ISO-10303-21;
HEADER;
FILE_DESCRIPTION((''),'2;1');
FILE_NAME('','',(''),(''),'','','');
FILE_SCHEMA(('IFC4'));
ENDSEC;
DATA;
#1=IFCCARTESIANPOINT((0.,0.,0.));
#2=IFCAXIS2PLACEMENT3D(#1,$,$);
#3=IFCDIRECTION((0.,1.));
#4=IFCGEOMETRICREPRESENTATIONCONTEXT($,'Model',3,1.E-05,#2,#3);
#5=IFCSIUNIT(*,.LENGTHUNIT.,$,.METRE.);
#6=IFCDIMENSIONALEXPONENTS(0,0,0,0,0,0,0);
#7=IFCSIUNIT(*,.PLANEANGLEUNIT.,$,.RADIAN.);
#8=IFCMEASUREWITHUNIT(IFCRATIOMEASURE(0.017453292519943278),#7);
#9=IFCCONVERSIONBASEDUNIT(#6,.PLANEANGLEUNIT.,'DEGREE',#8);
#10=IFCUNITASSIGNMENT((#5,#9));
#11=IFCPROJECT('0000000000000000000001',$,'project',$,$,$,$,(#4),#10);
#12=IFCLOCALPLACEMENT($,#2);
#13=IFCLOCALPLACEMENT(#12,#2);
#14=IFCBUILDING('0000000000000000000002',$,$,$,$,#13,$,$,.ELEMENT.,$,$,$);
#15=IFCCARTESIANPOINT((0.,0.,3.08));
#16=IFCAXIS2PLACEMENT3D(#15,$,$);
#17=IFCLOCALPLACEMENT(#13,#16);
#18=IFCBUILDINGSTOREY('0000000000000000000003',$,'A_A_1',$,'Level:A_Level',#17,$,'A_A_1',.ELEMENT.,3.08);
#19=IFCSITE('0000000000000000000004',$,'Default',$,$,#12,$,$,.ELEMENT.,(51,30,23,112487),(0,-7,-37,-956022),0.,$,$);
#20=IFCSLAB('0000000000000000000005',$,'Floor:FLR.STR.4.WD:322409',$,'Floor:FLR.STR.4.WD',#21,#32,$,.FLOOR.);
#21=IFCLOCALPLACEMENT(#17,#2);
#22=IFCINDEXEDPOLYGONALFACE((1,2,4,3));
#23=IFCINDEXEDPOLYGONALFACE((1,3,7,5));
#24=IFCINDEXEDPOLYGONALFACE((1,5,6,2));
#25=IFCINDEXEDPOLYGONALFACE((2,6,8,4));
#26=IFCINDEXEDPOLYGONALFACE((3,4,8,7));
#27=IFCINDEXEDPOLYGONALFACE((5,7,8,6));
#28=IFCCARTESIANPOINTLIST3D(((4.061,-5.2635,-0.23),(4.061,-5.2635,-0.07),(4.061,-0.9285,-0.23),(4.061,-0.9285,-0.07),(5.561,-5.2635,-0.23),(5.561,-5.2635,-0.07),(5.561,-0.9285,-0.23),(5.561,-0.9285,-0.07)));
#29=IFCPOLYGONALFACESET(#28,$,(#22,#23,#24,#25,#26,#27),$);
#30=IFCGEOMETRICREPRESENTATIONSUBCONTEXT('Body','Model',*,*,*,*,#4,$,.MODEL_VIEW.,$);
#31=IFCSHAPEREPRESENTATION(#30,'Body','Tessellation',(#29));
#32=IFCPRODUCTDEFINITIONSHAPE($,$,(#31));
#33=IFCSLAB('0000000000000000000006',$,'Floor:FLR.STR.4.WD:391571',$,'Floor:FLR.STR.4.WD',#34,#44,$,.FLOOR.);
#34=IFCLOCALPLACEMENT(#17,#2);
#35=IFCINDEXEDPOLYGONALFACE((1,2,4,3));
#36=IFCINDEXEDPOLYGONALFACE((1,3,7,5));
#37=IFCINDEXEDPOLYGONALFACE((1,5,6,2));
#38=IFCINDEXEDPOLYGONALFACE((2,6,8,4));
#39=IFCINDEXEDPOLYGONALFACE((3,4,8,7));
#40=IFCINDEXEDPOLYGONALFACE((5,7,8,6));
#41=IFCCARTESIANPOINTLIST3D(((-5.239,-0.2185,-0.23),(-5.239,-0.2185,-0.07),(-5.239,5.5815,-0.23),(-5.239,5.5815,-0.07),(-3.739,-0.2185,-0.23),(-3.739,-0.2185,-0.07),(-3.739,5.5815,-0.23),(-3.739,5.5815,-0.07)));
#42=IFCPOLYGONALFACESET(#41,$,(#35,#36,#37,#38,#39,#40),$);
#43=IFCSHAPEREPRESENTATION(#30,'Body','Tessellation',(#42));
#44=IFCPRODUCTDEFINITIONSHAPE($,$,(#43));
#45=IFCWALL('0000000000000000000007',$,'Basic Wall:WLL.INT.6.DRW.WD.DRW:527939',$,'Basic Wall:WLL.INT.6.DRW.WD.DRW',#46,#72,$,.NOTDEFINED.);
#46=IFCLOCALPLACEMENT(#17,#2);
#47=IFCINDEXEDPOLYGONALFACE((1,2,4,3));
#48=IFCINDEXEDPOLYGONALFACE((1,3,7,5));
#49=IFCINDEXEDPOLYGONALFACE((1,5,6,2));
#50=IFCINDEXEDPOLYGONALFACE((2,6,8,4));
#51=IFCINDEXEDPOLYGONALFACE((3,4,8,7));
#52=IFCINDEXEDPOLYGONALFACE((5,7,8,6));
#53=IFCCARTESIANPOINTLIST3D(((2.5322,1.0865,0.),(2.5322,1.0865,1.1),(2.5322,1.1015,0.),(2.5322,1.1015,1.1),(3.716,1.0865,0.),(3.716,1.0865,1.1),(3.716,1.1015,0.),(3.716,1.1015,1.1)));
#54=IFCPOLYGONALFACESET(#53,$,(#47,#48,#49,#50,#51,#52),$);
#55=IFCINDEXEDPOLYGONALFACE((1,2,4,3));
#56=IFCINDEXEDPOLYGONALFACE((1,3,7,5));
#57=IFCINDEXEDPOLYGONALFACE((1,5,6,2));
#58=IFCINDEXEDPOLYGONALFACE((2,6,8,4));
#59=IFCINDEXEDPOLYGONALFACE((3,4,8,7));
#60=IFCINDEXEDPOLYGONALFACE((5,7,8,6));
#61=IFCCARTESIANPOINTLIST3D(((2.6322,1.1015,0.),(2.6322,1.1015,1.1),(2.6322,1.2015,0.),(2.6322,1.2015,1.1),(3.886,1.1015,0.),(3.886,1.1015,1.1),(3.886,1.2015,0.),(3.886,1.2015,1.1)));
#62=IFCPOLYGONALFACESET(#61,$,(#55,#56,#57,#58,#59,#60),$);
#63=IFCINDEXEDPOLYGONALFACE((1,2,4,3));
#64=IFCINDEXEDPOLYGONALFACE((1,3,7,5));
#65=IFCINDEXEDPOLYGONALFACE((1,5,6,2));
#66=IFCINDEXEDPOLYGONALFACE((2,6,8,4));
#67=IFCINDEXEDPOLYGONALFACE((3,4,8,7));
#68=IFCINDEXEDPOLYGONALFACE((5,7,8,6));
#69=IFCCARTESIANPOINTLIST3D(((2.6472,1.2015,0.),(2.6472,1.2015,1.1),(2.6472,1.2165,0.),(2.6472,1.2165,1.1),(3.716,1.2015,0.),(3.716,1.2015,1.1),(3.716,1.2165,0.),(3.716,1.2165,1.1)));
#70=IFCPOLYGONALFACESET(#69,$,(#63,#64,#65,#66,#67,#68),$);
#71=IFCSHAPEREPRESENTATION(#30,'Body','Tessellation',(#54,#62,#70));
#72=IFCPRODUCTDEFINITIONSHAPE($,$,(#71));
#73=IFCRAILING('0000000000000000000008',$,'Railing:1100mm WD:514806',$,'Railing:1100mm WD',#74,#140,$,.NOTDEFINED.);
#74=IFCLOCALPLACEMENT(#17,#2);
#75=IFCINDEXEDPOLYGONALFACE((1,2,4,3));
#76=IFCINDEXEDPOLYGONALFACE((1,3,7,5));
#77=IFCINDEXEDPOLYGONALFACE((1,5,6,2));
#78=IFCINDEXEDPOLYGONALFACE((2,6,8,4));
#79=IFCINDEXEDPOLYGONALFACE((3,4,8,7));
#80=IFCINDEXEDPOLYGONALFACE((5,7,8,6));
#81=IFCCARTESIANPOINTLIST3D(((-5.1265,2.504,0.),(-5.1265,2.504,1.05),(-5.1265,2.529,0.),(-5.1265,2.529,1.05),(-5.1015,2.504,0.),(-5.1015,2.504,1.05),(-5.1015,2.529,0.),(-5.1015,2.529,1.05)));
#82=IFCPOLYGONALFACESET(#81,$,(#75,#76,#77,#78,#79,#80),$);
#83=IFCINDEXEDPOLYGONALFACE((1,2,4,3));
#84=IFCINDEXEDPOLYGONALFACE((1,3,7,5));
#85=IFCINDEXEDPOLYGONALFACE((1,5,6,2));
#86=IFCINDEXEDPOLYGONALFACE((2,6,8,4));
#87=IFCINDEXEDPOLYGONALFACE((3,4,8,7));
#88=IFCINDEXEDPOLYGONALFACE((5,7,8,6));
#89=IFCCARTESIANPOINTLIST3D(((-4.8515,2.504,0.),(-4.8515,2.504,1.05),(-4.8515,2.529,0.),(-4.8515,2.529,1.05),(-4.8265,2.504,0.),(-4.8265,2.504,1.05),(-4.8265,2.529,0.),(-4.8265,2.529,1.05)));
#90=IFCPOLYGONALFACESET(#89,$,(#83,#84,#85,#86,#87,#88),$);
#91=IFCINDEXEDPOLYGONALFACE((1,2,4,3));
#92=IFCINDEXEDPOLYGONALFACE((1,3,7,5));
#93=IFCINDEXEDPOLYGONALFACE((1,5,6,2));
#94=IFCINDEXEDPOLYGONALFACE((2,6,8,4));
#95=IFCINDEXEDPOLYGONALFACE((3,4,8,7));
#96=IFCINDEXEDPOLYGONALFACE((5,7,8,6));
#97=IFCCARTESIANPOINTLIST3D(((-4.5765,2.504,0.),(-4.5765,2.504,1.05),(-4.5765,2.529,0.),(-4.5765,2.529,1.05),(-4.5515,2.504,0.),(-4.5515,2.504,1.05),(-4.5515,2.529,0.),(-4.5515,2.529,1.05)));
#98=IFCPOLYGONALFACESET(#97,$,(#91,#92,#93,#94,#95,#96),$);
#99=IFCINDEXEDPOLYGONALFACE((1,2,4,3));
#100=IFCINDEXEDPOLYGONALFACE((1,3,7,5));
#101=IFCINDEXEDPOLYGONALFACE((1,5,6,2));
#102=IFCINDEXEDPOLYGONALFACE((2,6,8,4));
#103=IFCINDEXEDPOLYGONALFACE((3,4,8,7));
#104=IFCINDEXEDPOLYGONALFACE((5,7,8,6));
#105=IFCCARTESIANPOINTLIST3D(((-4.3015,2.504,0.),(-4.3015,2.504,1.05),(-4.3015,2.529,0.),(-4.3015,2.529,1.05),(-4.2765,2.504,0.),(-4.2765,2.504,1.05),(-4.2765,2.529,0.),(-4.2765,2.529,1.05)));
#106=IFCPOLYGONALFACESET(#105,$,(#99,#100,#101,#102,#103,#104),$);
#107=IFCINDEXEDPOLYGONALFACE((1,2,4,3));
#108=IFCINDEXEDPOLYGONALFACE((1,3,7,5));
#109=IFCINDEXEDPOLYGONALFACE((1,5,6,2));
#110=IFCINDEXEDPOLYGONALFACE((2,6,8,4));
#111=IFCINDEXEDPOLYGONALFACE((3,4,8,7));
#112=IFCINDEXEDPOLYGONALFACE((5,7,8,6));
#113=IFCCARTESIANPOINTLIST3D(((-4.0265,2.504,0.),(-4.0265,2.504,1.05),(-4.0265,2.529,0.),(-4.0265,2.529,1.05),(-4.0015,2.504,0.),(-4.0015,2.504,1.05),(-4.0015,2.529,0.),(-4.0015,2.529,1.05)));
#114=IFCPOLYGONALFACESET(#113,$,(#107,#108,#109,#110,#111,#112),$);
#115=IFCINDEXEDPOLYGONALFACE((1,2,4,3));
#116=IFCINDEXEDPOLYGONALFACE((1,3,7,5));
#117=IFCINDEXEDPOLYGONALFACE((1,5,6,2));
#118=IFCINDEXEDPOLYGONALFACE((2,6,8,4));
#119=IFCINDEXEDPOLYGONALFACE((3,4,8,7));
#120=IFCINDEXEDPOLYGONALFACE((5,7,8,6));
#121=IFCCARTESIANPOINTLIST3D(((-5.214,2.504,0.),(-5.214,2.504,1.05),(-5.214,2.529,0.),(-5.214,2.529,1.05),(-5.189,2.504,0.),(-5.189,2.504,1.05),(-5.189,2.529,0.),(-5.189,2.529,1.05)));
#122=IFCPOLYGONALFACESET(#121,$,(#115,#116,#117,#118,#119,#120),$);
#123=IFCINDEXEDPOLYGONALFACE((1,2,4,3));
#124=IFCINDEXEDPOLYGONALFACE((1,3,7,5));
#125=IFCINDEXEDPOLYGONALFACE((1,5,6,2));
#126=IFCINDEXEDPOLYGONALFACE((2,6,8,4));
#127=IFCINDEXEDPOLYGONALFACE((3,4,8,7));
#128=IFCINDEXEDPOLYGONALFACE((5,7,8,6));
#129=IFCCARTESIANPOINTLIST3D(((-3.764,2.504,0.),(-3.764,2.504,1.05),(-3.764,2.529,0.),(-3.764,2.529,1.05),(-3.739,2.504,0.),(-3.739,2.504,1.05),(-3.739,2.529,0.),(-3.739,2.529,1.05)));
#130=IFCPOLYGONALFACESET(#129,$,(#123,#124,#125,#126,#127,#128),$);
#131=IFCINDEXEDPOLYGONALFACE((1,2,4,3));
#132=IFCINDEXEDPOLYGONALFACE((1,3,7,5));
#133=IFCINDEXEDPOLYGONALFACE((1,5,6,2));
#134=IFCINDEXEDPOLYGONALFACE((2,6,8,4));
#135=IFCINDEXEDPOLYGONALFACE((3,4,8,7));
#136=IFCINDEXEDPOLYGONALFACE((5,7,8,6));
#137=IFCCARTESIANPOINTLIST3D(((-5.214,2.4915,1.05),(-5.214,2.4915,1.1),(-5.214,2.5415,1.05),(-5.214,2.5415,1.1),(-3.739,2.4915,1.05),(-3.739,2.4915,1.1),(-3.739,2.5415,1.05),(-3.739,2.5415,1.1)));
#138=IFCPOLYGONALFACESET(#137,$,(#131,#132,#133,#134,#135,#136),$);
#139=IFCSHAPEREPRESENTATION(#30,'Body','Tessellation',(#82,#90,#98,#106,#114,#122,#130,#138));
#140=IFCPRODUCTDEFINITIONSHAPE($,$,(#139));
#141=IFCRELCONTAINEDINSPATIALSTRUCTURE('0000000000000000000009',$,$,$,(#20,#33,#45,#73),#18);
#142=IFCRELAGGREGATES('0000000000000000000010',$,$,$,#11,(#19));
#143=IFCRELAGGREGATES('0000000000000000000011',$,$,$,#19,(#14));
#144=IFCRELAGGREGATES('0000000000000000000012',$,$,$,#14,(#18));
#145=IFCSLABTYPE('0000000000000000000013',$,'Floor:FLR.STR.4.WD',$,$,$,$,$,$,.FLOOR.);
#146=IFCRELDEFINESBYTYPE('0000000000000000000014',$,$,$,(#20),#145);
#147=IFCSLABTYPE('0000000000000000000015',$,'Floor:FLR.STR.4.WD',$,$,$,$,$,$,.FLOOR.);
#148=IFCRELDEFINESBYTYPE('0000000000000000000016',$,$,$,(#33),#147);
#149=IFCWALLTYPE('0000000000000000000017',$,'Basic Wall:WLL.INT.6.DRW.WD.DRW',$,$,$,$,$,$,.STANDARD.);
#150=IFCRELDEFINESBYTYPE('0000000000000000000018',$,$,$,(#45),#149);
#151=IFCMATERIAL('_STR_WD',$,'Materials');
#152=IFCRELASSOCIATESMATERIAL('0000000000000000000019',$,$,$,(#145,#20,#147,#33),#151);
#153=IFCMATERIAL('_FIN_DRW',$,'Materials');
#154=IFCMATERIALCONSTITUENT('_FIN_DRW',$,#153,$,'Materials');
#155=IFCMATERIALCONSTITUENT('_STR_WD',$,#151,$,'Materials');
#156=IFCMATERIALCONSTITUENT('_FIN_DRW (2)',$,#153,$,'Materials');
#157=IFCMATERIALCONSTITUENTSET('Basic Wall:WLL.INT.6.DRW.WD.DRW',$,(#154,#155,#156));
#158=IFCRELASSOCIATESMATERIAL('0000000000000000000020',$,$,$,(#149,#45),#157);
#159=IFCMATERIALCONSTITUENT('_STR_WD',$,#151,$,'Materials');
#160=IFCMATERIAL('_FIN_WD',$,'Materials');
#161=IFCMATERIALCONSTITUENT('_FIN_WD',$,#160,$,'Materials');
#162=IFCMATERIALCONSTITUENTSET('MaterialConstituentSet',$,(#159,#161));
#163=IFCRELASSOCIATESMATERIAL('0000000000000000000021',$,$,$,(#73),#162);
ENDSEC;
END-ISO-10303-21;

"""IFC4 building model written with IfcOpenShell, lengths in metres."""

from ifc_helpers import new_model, entity, si_unit, converted_unit, direction, frame, origin, place, context, subcontext, project, spatial, indexed_curve, outline, extrude, material, constituent, constituent_set, type_object, element, save


model = new_model("IFC4")

# Units and contexts
model_context = context("Model", 3, precision=1e-05, world=origin(), true_north=direction((0.0, 1.0)))
body_context = subcontext(model_context, "Body", "Model", "MODEL_VIEW")
ifc_project = project(units=[si_unit("LENGTHUNIT", "METRE"), converted_unit("PLANEANGLEUNIT", "DEGREE", entity("IfcRatioMeasure", 0.017453292519943278), si_unit("PLANEANGLEUNIT", "RADIAN"), dimensions=[0, 0, 0, 0, 0, 0, 0])], contexts=[model_context])

# Site, building, storey
site_placement = place(None, origin())
site = spatial("IfcSite", under=ifc_project, at=site_placement, Name="Default", CompositionType="ELEMENT", RefLatitude=(51, 30, 23, 112487), RefLongitude=(0, -7, -37, -956022), RefElevation=0.0)
building_placement = place(site_placement, origin())
building = spatial("IfcBuilding", under=site, at=building_placement, CompositionType="ELEMENT")
storey_placement = place(building_placement, frame((0.0, 0.0, 3.08)))
storey = spatial("IfcBuildingStorey", under=building, at=storey_placement, Name="A_A_1", ObjectType="Level:A_Level", LongName="A_A_1", CompositionType="ELEMENT", Elevation=3.08)

# Slabs
ifc_material_1 = material(Name="_FIN_WD", Category="Materials")
ifc_material_2 = material(Name="_STR_WD", Category="Materials")
slab_type_1 = type_object("IfcSlabType", Name="Floor:FLR.STR.4.WD", PredefinedType="FLOOR", material=ifc_material_2)
slab_1_placement = place(storey_placement, origin())
element("IfcSlab", 1, at=slab_1_placement, inside=storey, type_object=slab_type_1, material=ifc_material_2, Name="Floor:FLR.STR.4.WD:322409", ObjectType="Floor:FLR.STR.4.WD", PredefinedType="FLOOR", context=body_context, shape_type="SweptSolid", body=[
    extrude(outline(indexed_curve([(-0.75, -2.1675), (0.75, -2.1675), (0.75, 2.1675), (-0.75, 2.1675), (-0.75, -2.1675)], self_intersect=False)), frame((4.811, -3.096, -0.07), z_axis=(0.0, 0.0, -1.0), x_axis=(1.0, 0.0, 0.0)), (0.0, 0.0, 1.0), 0.16),
])
slab_type_2 = type_object("IfcSlabType", Name="Floor:FLR.STR.4.WD", PredefinedType="FLOOR", material=ifc_material_2)
slab_2_placement = place(storey_placement, origin())
element("IfcSlab", 2, at=slab_2_placement, inside=storey, type_object=slab_type_2, material=ifc_material_2, Name="Floor:FLR.STR.4.WD:391571", ObjectType="Floor:FLR.STR.4.WD", PredefinedType="FLOOR", context=body_context, shape_type="SweptSolid", body=[
    extrude(outline(indexed_curve([(-2.9, -0.75), (2.9, -0.75), (2.9, 0.75), (-2.9, 0.75), (-2.9, -0.75)], self_intersect=False)), frame((-4.489, 2.6815, -0.07), z_axis=(0.0, 0.0, -1.0), x_axis=(0.0, 1.0, 0.0)), (0.0, 0.0, 1.0), 0.16),
])

# Shared definitions
ifc_material_3 = material(Name="_FIN_DRW", Category="Materials")
ifc_constituent_1 = constituent(ifc_material_3, Name="_FIN_DRW", Category="Materials")
ifc_constituent_2 = constituent(ifc_material_2, Name="_STR_WD", Category="Materials")
ifc_constituent_3 = constituent(ifc_material_3, Name="_FIN_DRW (2)", Category="Materials")
ifc_constituent_set_1 = constituent_set(constituents=[ifc_constituent_1, ifc_constituent_2, ifc_constituent_3], Name="Basic Wall:WLL.INT.6.DRW.WD.DRW")
wall_type = type_object("IfcWallType", Name="Basic Wall:WLL.INT.6.DRW.WD.DRW", PredefinedType="STANDARD", material=ifc_constituent_set_1)

# Wall
wall_1_placement = place(storey_placement, frame((2.6472, 1.1515, 0.0)))
element("IfcWall", 3, at=wall_1_placement, inside=storey, type_object=wall_type, material=ifc_constituent_set_1, Name="Basic Wall:WLL.INT.6.DRW.WD.DRW:527939", ObjectType="Basic Wall:WLL.INT.6.DRW.WD.DRW", PredefinedType="NOTDEFINED", context=body_context, shape_type="SweptSolid", body=[
    extrude(outline(indexed_curve([(-0.0075, -0.5919), (0.0075, -0.5919), (0.0075, 0.5919), (-0.0075, 0.5919), (-0.0075, -0.5919)], self_intersect=False)), frame((0.4769, -0.0575, 0.0), z_axis=(0.0, 0.0, 1.0), x_axis=(0.0, 1.0, 0.0)), (0.0, 0.0, 1.0), 1.1),
    extrude(outline(indexed_curve([(-0.6269, -0.05), (0.6269, -0.05), (0.6269, 0.05), (-0.6269, 0.05), (-0.6269, -0.05)], self_intersect=False)), frame((0.6119, 0.0, 0.0)), (0.0, 0.0, 1.0), 1.1),
    extrude(outline(indexed_curve([(-0.0075, -0.5344), (0.0075, -0.5344), (0.0075, 0.5344), (-0.0075, 0.5344), (-0.0075, -0.5344)], self_intersect=False)), frame((0.5344, 0.0575, 0.0), z_axis=(0.0, 0.0, 1.0), x_axis=(0.0, -1.0, 0.0)), (0.0, 0.0, 1.0), 1.1),
])

# Railing
ifc_constituent_4 = constituent(ifc_material_2, Name="_STR_WD", Category="Materials")
ifc_constituent_5 = constituent(ifc_material_1, Name="_FIN_WD", Category="Materials")
ifc_constituent_set_2 = constituent_set(constituents=[ifc_constituent_4, ifc_constituent_5], Name="MaterialConstituentSet")
railing_placement = place(storey_placement, origin())
element("IfcRailing", 4, at=railing_placement, inside=storey, material=ifc_constituent_set_2, Name="Railing:1100mm WD:514806", ObjectType="Railing:1100mm WD", PredefinedType="NOTDEFINED", context=body_context, shape_type="SweptSolid", body=[
    extrude(outline(indexed_curve([(-0.0125, -0.0125), (0.0125, -0.0125), (0.0125, 0.0125), (-0.0125, 0.0125), (-0.0125, -0.0125)], self_intersect=False)), frame((-5.114, 2.5165, 0.0), z_axis=(0.0, 0.0, 1.0), x_axis=(-1.0, 0.0, 0.0)), (0.0, 0.0, 1.0), 1.05),
    extrude(outline(indexed_curve([(-0.0125, -0.0125), (0.0125, -0.0125), (0.0125, 0.0125), (-0.0125, 0.0125), (-0.0125, -0.0125)], self_intersect=False)), frame((-4.839, 2.5165, 0.0), z_axis=(0.0, 0.0, 1.0), x_axis=(-1.0, 0.0, 0.0)), (0.0, 0.0, 1.0), 1.05),
    extrude(outline(indexed_curve([(-0.0125, -0.0125), (0.0125, -0.0125), (0.0125, 0.0125), (-0.0125, 0.0125), (-0.0125, -0.0125)], self_intersect=False)), frame((-4.564, 2.5165, 0.0), z_axis=(0.0, 0.0, 1.0), x_axis=(-1.0, 0.0, 0.0)), (0.0, 0.0, 1.0), 1.05),
    extrude(outline(indexed_curve([(-0.0125, -0.0125), (0.0125, -0.0125), (0.0125, 0.0125), (-0.0125, 0.0125), (-0.0125, -0.0125)], self_intersect=False)), frame((-4.289, 2.5165, 0.0), z_axis=(0.0, 0.0, 1.0), x_axis=(-1.0, 0.0, 0.0)), (0.0, 0.0, 1.0), 1.05),
    extrude(outline(indexed_curve([(-0.0125, -0.0125), (0.0125, -0.0125), (0.0125, 0.0125), (-0.0125, 0.0125), (-0.0125, -0.0125)], self_intersect=False)), frame((-4.014, 2.5165, 0.0), z_axis=(0.0, 0.0, 1.0), x_axis=(-1.0, 0.0, 0.0)), (0.0, 0.0, 1.0), 1.05),
    extrude(outline(indexed_curve([(-0.0125, -0.0125), (0.0125, -0.0125), (0.0125, 0.0125), (-0.0125, 0.0125), (-0.0125, -0.0125)], self_intersect=False)), frame((-5.2015, 2.5165, 0.0), z_axis=(0.0, 0.0, 1.0), x_axis=(-1.0, 0.0, 0.0)), (0.0, 0.0, 1.0), 1.05),
    extrude(outline(indexed_curve([(-0.0125, -0.0125), (0.0125, -0.0125), (0.0125, 0.0125), (-0.0125, 0.0125), (-0.0125, -0.0125)], self_intersect=False)), frame((-3.7515, 2.5165, 0.0), z_axis=(0.0, 0.0, 1.0), x_axis=(-1.0, 0.0, 0.0)), (0.0, 0.0, 1.0), 1.05),
    extrude(outline(indexed_curve([(-0.7375, -0.025), (0.7375, -0.025), (0.7375, 0.025), (-0.7375, 0.025), (-0.7375, -0.025)], self_intersect=False)), frame((-4.4765, 2.5165, 1.05), z_axis=(0.0, 0.0, 1.0), x_axis=(-1.0, 0.0, 0.0)), (0.0, 0.0, 1.0), 0.05),
])

save(model, "model.ifc")
